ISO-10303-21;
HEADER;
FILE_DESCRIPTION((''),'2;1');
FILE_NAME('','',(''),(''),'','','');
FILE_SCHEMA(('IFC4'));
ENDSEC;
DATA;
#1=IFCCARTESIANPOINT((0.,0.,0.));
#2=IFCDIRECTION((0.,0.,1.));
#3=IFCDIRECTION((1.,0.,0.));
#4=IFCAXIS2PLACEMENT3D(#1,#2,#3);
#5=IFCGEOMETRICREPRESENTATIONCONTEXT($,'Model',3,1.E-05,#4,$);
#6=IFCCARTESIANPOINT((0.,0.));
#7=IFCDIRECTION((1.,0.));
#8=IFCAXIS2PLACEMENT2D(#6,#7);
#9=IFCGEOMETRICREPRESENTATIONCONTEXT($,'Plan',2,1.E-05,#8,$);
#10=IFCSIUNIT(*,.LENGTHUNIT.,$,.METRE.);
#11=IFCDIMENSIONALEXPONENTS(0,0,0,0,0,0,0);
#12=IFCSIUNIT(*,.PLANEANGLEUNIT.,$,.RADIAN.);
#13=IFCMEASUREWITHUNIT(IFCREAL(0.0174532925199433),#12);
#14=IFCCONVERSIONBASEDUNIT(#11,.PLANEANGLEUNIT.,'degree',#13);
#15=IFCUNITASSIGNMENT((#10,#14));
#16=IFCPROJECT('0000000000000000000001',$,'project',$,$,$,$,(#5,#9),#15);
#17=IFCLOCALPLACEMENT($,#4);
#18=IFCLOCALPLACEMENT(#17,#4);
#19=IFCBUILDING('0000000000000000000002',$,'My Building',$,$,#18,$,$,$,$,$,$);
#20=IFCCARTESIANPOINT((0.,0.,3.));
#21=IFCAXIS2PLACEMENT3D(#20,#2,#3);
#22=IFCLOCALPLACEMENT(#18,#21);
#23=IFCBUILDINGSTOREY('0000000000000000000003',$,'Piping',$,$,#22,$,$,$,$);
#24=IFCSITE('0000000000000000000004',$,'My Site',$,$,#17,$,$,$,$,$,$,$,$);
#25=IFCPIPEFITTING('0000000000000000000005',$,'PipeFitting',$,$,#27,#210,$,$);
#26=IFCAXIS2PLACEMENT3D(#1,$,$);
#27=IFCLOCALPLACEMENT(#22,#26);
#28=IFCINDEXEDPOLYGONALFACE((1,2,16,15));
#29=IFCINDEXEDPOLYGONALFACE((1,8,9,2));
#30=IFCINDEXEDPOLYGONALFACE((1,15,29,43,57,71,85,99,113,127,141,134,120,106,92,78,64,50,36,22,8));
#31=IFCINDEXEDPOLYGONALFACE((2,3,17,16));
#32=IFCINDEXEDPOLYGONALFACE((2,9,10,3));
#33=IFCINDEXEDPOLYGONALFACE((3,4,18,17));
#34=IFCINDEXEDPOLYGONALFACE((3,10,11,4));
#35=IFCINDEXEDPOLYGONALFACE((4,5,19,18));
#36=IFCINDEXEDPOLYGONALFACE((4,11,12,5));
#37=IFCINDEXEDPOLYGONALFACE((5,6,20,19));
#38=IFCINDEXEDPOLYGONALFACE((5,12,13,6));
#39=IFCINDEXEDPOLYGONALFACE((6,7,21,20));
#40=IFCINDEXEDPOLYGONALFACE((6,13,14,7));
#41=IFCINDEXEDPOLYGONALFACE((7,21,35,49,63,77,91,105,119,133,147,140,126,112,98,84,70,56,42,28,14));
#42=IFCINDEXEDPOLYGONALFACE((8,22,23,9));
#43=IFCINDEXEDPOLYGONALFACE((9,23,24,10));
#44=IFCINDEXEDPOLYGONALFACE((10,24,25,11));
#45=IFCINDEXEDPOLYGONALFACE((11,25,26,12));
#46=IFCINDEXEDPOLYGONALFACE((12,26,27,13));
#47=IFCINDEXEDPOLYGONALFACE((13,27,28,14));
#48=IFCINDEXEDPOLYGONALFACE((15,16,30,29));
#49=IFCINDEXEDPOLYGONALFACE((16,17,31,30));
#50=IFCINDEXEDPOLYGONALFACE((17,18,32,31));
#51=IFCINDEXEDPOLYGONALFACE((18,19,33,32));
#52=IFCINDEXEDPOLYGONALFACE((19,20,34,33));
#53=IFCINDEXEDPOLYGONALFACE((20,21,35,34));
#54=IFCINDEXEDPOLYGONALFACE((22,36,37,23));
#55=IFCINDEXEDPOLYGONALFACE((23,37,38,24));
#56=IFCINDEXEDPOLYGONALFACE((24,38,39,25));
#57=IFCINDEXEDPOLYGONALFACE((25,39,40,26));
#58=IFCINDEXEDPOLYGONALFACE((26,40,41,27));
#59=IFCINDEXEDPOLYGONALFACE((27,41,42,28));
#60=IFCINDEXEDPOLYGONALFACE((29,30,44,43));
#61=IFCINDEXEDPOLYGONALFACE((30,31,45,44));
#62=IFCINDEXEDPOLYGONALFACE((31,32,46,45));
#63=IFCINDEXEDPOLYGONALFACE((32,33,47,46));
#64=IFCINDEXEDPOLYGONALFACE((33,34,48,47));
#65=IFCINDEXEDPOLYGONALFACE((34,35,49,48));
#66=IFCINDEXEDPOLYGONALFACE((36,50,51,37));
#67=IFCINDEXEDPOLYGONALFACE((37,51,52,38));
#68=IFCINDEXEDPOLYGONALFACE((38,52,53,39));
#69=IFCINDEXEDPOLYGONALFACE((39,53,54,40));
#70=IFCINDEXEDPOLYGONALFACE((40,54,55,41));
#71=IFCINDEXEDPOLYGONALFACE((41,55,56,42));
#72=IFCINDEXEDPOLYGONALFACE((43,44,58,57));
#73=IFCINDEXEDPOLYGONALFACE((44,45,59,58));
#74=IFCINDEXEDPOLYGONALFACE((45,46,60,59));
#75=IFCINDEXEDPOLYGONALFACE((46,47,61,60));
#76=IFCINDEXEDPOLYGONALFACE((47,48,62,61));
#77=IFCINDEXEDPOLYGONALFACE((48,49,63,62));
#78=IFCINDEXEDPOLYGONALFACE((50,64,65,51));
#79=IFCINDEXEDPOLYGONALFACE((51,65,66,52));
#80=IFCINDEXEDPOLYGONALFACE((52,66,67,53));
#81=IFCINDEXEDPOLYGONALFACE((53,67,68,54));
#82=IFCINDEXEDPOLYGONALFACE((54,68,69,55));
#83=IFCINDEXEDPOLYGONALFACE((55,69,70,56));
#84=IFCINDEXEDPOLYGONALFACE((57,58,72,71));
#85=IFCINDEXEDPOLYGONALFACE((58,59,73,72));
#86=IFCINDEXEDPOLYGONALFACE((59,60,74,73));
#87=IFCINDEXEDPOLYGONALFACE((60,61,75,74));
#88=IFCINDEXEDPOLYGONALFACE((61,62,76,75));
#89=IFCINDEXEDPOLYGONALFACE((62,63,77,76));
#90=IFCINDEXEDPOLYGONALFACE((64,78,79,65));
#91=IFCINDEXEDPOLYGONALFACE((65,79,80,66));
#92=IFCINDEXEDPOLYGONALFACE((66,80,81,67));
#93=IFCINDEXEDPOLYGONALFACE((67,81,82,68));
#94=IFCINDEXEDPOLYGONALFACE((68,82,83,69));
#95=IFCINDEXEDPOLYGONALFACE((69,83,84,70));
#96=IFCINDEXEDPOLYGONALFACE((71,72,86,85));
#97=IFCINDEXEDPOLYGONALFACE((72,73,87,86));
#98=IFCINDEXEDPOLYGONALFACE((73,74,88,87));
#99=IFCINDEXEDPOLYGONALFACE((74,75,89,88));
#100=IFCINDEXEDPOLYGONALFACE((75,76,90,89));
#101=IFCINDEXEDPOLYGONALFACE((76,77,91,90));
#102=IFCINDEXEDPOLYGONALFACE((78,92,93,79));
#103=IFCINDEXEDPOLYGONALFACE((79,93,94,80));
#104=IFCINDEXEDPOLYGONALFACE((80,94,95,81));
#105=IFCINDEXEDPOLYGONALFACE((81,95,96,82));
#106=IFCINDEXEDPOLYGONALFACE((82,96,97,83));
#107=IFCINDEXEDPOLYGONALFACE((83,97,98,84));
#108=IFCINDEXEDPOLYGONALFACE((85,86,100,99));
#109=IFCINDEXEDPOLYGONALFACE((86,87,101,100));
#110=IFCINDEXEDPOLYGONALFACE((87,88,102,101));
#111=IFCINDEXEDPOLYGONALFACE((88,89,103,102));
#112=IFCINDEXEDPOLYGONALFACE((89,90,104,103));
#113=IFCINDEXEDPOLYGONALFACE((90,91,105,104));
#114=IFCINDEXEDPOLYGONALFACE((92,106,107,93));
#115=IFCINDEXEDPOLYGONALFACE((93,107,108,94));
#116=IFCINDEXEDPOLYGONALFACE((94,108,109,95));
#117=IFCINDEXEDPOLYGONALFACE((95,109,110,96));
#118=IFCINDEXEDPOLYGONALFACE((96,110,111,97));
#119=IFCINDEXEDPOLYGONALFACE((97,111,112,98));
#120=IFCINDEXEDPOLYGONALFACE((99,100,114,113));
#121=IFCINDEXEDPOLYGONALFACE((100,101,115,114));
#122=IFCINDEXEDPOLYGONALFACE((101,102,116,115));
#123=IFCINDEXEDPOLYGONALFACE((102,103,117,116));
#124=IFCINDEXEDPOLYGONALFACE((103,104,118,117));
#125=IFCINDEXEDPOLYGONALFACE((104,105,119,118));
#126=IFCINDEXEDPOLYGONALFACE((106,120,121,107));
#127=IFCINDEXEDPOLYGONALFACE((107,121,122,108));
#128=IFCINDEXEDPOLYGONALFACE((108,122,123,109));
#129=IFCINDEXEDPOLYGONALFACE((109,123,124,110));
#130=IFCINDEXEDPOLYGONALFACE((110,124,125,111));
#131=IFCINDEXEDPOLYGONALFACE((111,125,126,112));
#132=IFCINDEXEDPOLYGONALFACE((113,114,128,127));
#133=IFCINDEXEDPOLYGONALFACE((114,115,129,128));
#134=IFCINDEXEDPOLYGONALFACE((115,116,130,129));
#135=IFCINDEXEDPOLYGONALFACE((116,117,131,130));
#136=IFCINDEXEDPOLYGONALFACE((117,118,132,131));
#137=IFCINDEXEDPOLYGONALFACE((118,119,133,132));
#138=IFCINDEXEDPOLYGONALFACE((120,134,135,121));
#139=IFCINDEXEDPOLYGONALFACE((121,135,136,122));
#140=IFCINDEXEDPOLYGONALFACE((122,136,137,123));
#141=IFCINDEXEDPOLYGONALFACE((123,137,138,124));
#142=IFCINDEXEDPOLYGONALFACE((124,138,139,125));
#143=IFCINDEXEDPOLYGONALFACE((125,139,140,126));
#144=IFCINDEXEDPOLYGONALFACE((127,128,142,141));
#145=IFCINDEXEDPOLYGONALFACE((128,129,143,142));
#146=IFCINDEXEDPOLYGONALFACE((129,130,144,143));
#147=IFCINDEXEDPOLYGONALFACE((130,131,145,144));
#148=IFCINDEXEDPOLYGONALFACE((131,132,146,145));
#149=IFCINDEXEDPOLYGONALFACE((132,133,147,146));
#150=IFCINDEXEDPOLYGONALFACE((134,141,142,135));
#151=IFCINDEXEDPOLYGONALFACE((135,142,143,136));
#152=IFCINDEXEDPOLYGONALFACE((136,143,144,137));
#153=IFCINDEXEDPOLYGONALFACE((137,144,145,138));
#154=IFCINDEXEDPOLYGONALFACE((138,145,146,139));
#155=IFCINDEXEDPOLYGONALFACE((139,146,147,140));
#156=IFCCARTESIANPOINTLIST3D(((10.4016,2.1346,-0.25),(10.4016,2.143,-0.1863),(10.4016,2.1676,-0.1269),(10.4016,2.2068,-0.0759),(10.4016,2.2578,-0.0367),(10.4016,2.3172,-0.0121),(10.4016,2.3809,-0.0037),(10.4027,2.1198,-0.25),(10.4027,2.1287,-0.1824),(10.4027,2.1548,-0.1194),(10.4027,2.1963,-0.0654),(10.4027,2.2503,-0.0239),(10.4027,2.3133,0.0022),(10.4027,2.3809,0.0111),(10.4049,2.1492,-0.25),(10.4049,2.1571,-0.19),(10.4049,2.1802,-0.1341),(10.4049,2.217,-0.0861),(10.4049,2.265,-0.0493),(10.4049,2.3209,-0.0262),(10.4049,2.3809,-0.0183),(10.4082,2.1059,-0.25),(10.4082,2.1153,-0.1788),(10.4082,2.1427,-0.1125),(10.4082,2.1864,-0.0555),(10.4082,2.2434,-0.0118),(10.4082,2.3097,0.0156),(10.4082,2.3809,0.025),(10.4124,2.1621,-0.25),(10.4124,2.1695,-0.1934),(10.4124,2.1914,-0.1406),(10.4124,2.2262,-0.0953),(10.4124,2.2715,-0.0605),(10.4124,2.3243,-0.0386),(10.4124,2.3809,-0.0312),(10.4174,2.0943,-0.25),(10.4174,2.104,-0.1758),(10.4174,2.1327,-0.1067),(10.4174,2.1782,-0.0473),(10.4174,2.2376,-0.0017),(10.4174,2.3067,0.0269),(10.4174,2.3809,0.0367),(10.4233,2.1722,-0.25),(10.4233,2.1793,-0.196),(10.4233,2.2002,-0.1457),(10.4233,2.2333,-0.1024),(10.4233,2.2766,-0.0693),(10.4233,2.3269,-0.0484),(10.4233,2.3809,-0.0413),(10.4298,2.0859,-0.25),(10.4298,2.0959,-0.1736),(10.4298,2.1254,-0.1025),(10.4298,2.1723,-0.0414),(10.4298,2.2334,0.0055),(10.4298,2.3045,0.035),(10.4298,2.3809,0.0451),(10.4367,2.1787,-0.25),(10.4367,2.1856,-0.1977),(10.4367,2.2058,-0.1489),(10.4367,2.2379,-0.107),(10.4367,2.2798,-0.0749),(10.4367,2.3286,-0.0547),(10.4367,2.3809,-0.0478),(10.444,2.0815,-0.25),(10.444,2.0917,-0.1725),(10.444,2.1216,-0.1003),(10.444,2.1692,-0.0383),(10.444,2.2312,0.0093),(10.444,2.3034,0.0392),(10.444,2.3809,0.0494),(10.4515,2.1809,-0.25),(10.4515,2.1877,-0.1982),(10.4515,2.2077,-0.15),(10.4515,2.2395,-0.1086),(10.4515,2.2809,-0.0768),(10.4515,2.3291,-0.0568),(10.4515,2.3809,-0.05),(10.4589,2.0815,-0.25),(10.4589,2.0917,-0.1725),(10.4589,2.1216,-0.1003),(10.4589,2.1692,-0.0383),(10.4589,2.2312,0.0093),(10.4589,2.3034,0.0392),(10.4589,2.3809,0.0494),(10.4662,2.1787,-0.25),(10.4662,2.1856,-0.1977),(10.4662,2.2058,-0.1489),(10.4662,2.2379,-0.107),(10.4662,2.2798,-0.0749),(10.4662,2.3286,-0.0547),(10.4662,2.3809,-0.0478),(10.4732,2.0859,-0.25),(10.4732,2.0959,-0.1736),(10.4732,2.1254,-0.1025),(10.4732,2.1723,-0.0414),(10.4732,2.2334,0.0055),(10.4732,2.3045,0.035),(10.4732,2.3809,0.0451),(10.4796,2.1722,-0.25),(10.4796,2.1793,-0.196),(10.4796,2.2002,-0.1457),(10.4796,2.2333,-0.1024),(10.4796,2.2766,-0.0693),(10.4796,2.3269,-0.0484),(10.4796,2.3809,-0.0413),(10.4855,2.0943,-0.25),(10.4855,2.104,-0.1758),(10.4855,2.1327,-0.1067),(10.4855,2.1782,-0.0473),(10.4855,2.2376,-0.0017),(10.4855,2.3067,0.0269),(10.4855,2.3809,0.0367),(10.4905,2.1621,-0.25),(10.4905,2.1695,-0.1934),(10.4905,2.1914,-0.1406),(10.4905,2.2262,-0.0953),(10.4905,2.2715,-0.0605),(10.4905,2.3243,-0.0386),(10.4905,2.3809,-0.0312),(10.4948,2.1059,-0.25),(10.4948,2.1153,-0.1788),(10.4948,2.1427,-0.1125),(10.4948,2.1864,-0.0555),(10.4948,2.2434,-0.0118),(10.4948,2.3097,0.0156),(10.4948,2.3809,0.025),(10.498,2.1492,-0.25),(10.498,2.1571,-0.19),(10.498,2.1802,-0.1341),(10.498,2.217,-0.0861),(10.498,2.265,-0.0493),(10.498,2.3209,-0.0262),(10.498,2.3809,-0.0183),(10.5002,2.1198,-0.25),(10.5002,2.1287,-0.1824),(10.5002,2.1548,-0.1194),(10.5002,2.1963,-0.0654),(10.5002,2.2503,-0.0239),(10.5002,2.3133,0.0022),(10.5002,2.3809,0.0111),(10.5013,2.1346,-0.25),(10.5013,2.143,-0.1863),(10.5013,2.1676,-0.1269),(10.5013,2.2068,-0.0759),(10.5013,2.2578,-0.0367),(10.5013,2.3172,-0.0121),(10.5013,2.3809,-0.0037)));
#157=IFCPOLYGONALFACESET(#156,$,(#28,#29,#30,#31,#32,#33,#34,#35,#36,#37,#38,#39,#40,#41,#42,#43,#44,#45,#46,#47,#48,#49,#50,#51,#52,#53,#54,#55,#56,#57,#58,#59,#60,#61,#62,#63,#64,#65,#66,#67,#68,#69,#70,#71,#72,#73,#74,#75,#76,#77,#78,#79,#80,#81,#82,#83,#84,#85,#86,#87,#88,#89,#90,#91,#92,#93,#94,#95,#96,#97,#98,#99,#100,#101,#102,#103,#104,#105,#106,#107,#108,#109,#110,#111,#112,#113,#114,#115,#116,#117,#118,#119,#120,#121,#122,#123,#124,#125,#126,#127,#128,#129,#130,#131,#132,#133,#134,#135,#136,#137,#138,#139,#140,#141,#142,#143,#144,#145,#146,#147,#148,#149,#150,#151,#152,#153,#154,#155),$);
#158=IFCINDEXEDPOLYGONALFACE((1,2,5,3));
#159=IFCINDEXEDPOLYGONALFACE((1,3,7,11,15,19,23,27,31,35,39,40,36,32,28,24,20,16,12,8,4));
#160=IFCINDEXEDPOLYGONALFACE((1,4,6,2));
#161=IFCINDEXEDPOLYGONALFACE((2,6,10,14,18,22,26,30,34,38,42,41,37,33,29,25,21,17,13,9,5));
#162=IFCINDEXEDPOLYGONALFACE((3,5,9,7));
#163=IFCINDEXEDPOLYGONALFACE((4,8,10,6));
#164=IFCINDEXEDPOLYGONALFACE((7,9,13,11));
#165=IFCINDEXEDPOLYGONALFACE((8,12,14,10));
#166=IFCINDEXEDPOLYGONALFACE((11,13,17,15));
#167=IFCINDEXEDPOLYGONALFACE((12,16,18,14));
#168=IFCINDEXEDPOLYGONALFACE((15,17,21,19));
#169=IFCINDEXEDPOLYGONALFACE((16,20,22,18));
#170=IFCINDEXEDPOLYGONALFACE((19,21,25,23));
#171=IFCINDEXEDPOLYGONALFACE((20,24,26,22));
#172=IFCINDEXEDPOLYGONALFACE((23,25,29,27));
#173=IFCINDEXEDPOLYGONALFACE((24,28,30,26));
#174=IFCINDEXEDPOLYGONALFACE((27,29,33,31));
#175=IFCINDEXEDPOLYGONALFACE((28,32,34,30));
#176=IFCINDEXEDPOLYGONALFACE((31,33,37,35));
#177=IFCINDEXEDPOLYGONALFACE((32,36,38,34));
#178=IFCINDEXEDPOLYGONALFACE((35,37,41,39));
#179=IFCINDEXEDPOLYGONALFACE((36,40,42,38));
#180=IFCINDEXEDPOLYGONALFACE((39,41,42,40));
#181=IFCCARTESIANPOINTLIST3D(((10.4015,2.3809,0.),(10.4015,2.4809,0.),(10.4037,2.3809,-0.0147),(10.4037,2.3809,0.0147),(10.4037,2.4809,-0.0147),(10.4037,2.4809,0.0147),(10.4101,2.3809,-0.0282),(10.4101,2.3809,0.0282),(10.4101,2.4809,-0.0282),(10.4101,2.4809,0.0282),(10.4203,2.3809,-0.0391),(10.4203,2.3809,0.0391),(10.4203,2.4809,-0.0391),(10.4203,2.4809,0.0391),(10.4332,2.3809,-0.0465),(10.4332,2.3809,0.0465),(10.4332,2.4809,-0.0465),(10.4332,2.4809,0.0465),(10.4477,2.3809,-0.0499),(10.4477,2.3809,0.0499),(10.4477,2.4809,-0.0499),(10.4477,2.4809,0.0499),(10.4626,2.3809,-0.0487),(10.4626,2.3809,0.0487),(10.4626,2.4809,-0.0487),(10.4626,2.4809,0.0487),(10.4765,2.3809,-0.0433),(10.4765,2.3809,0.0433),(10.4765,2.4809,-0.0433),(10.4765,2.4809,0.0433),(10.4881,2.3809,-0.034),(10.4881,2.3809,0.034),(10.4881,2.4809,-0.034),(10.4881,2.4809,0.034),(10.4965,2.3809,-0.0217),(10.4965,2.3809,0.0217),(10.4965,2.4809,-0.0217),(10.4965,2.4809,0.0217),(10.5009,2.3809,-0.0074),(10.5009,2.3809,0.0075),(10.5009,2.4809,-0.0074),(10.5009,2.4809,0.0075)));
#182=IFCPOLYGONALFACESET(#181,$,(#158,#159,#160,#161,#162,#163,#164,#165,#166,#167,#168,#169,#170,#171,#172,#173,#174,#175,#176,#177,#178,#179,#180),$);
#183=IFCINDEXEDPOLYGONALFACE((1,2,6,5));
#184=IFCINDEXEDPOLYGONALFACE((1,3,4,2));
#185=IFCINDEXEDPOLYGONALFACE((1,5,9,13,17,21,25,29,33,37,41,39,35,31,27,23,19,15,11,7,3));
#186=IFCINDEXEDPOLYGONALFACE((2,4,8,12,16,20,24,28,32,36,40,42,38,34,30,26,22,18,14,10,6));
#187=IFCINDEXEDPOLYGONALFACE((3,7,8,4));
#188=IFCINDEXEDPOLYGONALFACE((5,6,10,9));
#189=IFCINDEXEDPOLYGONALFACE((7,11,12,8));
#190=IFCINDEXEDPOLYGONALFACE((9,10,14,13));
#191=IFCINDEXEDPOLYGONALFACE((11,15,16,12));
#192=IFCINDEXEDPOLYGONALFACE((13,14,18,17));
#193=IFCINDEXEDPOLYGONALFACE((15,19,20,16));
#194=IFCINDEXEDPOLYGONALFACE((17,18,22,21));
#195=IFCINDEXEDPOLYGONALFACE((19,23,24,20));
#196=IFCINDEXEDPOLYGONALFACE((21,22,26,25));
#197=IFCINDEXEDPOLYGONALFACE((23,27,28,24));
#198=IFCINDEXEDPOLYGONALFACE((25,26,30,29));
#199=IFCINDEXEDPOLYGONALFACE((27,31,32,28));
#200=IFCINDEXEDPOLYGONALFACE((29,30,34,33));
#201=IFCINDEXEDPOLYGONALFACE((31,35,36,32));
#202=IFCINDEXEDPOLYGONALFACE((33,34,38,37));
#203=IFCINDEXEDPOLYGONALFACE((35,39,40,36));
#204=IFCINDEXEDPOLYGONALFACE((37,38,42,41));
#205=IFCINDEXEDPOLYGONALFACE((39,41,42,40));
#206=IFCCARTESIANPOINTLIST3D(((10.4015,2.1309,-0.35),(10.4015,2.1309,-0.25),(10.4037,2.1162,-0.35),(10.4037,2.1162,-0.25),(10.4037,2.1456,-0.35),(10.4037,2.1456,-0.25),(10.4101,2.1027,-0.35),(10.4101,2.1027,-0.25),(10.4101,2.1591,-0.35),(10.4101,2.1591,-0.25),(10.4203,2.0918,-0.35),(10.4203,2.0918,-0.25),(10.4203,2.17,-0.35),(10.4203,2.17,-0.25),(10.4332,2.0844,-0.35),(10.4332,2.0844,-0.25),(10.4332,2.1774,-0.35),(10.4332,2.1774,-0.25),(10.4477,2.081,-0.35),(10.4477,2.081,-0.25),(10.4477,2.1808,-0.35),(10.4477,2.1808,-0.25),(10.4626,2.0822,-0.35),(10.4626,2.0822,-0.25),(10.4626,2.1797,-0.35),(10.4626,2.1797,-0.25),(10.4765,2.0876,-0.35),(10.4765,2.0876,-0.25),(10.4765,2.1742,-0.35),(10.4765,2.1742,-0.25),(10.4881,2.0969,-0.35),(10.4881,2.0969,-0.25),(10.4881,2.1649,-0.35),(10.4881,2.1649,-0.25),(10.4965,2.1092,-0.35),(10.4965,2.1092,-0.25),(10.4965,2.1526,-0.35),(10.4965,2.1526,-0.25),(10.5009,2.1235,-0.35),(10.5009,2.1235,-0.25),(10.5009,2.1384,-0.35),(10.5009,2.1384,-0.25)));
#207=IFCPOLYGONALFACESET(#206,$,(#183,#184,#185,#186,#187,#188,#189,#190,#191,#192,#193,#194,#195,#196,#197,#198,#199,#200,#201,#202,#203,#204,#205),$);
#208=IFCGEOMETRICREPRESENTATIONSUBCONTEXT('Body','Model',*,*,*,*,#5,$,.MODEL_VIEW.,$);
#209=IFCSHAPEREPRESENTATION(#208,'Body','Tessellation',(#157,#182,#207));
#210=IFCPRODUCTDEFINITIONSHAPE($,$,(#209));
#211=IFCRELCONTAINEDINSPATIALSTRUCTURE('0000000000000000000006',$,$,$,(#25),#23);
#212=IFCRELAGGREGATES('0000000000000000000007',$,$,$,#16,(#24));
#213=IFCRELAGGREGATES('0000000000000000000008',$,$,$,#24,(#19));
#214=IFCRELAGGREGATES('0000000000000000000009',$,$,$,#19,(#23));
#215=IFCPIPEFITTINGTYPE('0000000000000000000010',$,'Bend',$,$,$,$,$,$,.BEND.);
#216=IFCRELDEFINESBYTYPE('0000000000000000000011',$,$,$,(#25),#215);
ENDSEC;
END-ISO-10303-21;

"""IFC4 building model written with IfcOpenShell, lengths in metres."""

from ifc_helpers import new_model, entity, si_unit, converted_unit, frame, origin_with_axes, origin_2d_with_axis, place, context, subcontext, project, spatial, circle, extrude, source, transform, mapped, type_object, type_shapes, element, save


model = new_model("IFC4")

# Units and contexts
model_context = context("Model", 3, precision=1e-05, world=origin_with_axes())
plan_context = context("Plan", 2, precision=1e-05, world=origin_2d_with_axis())
body_context = subcontext(model_context, "Body", "Model", "MODEL_VIEW")
ifc_project = project(units=[si_unit("LENGTHUNIT", "METRE"), converted_unit("PLANEANGLEUNIT", "degree", entity("IfcReal", 0.0174532925199433), si_unit("PLANEANGLEUNIT", "RADIAN"), dimensions=[0, 0, 0, 0, 0, 0, 0])], contexts=[model_context, plan_context])

# Site, building, storey
site_placement = place(None, origin_with_axes())
site = spatial("IfcSite", under=ifc_project, at=site_placement, Name="My Site")
building_placement = place(site_placement, origin_with_axes())
building = spatial("IfcBuilding", under=site, at=building_placement, Name="My Building")
storey_placement = place(building_placement, frame((0.0, 0.0, 3.0), z_axis=(0.0, 0.0, 1.0), x_axis=(1.0, 0.0, 0.0)))
storey = spatial("IfcBuildingStorey", under=building, at=storey_placement, Name="Piping")

# Pipe fitting
pipe_fitting_type = type_object("IfcPipeFittingType", Name="Bend", PredefinedType="BEND")
shared_shape = source(origin_with_axes(), body_context, "Body", "SolidModel", [
    entity("IfcSweptDiskSolid", entity("IfcIndexedPolyCurve", entity("IfcCartesianPointList3D", [[0.0, 0.0, -0.1], [0.0, -0.0732, -0.2768], [0.0, -0.25, -0.35]]), [entity("IfcArcIndex", [1, 2, 3])]), 0.05),
    extrude(circle(Radius=0.05), origin_with_axes(), (0.0, 0.0, -1.0), 0.1),
    extrude(circle(Radius=0.05), frame((0.0, -0.25, -0.35), z_axis=(0.0, -1.0, 0.0), x_axis=(1.0, 0.0, 0.0)), (0.0, 0.0, 1.0), 0.1),
])
type_shapes(pipe_fitting_type, [shared_shape])
for number, where, z_axis, x_axis, name in (
    (1, (10.4515, 2.4809, 0.0), (0.0, 1.0, 0.0), (-1.0, 0.0, 0.0), "PipeFitting"),
):
    element("IfcPipeFitting", number, at=place(storey_placement, frame(where, z_axis=z_axis, x_axis=x_axis)), inside=storey, type_object=pipe_fitting_type, Name=name, context=body_context, shape_type="MappedRepresentation", body=[
        mapped(shared_shape, transform((0.0, 0.0, 0.0), x_axis=(1.0, 0.0, 0.0), y_axis=(0.0, 1.0, 0.0), z_axis=(0.0, 0.0, 1.0), scale=1.0)),
    ])

save(model, "model.ifc")
